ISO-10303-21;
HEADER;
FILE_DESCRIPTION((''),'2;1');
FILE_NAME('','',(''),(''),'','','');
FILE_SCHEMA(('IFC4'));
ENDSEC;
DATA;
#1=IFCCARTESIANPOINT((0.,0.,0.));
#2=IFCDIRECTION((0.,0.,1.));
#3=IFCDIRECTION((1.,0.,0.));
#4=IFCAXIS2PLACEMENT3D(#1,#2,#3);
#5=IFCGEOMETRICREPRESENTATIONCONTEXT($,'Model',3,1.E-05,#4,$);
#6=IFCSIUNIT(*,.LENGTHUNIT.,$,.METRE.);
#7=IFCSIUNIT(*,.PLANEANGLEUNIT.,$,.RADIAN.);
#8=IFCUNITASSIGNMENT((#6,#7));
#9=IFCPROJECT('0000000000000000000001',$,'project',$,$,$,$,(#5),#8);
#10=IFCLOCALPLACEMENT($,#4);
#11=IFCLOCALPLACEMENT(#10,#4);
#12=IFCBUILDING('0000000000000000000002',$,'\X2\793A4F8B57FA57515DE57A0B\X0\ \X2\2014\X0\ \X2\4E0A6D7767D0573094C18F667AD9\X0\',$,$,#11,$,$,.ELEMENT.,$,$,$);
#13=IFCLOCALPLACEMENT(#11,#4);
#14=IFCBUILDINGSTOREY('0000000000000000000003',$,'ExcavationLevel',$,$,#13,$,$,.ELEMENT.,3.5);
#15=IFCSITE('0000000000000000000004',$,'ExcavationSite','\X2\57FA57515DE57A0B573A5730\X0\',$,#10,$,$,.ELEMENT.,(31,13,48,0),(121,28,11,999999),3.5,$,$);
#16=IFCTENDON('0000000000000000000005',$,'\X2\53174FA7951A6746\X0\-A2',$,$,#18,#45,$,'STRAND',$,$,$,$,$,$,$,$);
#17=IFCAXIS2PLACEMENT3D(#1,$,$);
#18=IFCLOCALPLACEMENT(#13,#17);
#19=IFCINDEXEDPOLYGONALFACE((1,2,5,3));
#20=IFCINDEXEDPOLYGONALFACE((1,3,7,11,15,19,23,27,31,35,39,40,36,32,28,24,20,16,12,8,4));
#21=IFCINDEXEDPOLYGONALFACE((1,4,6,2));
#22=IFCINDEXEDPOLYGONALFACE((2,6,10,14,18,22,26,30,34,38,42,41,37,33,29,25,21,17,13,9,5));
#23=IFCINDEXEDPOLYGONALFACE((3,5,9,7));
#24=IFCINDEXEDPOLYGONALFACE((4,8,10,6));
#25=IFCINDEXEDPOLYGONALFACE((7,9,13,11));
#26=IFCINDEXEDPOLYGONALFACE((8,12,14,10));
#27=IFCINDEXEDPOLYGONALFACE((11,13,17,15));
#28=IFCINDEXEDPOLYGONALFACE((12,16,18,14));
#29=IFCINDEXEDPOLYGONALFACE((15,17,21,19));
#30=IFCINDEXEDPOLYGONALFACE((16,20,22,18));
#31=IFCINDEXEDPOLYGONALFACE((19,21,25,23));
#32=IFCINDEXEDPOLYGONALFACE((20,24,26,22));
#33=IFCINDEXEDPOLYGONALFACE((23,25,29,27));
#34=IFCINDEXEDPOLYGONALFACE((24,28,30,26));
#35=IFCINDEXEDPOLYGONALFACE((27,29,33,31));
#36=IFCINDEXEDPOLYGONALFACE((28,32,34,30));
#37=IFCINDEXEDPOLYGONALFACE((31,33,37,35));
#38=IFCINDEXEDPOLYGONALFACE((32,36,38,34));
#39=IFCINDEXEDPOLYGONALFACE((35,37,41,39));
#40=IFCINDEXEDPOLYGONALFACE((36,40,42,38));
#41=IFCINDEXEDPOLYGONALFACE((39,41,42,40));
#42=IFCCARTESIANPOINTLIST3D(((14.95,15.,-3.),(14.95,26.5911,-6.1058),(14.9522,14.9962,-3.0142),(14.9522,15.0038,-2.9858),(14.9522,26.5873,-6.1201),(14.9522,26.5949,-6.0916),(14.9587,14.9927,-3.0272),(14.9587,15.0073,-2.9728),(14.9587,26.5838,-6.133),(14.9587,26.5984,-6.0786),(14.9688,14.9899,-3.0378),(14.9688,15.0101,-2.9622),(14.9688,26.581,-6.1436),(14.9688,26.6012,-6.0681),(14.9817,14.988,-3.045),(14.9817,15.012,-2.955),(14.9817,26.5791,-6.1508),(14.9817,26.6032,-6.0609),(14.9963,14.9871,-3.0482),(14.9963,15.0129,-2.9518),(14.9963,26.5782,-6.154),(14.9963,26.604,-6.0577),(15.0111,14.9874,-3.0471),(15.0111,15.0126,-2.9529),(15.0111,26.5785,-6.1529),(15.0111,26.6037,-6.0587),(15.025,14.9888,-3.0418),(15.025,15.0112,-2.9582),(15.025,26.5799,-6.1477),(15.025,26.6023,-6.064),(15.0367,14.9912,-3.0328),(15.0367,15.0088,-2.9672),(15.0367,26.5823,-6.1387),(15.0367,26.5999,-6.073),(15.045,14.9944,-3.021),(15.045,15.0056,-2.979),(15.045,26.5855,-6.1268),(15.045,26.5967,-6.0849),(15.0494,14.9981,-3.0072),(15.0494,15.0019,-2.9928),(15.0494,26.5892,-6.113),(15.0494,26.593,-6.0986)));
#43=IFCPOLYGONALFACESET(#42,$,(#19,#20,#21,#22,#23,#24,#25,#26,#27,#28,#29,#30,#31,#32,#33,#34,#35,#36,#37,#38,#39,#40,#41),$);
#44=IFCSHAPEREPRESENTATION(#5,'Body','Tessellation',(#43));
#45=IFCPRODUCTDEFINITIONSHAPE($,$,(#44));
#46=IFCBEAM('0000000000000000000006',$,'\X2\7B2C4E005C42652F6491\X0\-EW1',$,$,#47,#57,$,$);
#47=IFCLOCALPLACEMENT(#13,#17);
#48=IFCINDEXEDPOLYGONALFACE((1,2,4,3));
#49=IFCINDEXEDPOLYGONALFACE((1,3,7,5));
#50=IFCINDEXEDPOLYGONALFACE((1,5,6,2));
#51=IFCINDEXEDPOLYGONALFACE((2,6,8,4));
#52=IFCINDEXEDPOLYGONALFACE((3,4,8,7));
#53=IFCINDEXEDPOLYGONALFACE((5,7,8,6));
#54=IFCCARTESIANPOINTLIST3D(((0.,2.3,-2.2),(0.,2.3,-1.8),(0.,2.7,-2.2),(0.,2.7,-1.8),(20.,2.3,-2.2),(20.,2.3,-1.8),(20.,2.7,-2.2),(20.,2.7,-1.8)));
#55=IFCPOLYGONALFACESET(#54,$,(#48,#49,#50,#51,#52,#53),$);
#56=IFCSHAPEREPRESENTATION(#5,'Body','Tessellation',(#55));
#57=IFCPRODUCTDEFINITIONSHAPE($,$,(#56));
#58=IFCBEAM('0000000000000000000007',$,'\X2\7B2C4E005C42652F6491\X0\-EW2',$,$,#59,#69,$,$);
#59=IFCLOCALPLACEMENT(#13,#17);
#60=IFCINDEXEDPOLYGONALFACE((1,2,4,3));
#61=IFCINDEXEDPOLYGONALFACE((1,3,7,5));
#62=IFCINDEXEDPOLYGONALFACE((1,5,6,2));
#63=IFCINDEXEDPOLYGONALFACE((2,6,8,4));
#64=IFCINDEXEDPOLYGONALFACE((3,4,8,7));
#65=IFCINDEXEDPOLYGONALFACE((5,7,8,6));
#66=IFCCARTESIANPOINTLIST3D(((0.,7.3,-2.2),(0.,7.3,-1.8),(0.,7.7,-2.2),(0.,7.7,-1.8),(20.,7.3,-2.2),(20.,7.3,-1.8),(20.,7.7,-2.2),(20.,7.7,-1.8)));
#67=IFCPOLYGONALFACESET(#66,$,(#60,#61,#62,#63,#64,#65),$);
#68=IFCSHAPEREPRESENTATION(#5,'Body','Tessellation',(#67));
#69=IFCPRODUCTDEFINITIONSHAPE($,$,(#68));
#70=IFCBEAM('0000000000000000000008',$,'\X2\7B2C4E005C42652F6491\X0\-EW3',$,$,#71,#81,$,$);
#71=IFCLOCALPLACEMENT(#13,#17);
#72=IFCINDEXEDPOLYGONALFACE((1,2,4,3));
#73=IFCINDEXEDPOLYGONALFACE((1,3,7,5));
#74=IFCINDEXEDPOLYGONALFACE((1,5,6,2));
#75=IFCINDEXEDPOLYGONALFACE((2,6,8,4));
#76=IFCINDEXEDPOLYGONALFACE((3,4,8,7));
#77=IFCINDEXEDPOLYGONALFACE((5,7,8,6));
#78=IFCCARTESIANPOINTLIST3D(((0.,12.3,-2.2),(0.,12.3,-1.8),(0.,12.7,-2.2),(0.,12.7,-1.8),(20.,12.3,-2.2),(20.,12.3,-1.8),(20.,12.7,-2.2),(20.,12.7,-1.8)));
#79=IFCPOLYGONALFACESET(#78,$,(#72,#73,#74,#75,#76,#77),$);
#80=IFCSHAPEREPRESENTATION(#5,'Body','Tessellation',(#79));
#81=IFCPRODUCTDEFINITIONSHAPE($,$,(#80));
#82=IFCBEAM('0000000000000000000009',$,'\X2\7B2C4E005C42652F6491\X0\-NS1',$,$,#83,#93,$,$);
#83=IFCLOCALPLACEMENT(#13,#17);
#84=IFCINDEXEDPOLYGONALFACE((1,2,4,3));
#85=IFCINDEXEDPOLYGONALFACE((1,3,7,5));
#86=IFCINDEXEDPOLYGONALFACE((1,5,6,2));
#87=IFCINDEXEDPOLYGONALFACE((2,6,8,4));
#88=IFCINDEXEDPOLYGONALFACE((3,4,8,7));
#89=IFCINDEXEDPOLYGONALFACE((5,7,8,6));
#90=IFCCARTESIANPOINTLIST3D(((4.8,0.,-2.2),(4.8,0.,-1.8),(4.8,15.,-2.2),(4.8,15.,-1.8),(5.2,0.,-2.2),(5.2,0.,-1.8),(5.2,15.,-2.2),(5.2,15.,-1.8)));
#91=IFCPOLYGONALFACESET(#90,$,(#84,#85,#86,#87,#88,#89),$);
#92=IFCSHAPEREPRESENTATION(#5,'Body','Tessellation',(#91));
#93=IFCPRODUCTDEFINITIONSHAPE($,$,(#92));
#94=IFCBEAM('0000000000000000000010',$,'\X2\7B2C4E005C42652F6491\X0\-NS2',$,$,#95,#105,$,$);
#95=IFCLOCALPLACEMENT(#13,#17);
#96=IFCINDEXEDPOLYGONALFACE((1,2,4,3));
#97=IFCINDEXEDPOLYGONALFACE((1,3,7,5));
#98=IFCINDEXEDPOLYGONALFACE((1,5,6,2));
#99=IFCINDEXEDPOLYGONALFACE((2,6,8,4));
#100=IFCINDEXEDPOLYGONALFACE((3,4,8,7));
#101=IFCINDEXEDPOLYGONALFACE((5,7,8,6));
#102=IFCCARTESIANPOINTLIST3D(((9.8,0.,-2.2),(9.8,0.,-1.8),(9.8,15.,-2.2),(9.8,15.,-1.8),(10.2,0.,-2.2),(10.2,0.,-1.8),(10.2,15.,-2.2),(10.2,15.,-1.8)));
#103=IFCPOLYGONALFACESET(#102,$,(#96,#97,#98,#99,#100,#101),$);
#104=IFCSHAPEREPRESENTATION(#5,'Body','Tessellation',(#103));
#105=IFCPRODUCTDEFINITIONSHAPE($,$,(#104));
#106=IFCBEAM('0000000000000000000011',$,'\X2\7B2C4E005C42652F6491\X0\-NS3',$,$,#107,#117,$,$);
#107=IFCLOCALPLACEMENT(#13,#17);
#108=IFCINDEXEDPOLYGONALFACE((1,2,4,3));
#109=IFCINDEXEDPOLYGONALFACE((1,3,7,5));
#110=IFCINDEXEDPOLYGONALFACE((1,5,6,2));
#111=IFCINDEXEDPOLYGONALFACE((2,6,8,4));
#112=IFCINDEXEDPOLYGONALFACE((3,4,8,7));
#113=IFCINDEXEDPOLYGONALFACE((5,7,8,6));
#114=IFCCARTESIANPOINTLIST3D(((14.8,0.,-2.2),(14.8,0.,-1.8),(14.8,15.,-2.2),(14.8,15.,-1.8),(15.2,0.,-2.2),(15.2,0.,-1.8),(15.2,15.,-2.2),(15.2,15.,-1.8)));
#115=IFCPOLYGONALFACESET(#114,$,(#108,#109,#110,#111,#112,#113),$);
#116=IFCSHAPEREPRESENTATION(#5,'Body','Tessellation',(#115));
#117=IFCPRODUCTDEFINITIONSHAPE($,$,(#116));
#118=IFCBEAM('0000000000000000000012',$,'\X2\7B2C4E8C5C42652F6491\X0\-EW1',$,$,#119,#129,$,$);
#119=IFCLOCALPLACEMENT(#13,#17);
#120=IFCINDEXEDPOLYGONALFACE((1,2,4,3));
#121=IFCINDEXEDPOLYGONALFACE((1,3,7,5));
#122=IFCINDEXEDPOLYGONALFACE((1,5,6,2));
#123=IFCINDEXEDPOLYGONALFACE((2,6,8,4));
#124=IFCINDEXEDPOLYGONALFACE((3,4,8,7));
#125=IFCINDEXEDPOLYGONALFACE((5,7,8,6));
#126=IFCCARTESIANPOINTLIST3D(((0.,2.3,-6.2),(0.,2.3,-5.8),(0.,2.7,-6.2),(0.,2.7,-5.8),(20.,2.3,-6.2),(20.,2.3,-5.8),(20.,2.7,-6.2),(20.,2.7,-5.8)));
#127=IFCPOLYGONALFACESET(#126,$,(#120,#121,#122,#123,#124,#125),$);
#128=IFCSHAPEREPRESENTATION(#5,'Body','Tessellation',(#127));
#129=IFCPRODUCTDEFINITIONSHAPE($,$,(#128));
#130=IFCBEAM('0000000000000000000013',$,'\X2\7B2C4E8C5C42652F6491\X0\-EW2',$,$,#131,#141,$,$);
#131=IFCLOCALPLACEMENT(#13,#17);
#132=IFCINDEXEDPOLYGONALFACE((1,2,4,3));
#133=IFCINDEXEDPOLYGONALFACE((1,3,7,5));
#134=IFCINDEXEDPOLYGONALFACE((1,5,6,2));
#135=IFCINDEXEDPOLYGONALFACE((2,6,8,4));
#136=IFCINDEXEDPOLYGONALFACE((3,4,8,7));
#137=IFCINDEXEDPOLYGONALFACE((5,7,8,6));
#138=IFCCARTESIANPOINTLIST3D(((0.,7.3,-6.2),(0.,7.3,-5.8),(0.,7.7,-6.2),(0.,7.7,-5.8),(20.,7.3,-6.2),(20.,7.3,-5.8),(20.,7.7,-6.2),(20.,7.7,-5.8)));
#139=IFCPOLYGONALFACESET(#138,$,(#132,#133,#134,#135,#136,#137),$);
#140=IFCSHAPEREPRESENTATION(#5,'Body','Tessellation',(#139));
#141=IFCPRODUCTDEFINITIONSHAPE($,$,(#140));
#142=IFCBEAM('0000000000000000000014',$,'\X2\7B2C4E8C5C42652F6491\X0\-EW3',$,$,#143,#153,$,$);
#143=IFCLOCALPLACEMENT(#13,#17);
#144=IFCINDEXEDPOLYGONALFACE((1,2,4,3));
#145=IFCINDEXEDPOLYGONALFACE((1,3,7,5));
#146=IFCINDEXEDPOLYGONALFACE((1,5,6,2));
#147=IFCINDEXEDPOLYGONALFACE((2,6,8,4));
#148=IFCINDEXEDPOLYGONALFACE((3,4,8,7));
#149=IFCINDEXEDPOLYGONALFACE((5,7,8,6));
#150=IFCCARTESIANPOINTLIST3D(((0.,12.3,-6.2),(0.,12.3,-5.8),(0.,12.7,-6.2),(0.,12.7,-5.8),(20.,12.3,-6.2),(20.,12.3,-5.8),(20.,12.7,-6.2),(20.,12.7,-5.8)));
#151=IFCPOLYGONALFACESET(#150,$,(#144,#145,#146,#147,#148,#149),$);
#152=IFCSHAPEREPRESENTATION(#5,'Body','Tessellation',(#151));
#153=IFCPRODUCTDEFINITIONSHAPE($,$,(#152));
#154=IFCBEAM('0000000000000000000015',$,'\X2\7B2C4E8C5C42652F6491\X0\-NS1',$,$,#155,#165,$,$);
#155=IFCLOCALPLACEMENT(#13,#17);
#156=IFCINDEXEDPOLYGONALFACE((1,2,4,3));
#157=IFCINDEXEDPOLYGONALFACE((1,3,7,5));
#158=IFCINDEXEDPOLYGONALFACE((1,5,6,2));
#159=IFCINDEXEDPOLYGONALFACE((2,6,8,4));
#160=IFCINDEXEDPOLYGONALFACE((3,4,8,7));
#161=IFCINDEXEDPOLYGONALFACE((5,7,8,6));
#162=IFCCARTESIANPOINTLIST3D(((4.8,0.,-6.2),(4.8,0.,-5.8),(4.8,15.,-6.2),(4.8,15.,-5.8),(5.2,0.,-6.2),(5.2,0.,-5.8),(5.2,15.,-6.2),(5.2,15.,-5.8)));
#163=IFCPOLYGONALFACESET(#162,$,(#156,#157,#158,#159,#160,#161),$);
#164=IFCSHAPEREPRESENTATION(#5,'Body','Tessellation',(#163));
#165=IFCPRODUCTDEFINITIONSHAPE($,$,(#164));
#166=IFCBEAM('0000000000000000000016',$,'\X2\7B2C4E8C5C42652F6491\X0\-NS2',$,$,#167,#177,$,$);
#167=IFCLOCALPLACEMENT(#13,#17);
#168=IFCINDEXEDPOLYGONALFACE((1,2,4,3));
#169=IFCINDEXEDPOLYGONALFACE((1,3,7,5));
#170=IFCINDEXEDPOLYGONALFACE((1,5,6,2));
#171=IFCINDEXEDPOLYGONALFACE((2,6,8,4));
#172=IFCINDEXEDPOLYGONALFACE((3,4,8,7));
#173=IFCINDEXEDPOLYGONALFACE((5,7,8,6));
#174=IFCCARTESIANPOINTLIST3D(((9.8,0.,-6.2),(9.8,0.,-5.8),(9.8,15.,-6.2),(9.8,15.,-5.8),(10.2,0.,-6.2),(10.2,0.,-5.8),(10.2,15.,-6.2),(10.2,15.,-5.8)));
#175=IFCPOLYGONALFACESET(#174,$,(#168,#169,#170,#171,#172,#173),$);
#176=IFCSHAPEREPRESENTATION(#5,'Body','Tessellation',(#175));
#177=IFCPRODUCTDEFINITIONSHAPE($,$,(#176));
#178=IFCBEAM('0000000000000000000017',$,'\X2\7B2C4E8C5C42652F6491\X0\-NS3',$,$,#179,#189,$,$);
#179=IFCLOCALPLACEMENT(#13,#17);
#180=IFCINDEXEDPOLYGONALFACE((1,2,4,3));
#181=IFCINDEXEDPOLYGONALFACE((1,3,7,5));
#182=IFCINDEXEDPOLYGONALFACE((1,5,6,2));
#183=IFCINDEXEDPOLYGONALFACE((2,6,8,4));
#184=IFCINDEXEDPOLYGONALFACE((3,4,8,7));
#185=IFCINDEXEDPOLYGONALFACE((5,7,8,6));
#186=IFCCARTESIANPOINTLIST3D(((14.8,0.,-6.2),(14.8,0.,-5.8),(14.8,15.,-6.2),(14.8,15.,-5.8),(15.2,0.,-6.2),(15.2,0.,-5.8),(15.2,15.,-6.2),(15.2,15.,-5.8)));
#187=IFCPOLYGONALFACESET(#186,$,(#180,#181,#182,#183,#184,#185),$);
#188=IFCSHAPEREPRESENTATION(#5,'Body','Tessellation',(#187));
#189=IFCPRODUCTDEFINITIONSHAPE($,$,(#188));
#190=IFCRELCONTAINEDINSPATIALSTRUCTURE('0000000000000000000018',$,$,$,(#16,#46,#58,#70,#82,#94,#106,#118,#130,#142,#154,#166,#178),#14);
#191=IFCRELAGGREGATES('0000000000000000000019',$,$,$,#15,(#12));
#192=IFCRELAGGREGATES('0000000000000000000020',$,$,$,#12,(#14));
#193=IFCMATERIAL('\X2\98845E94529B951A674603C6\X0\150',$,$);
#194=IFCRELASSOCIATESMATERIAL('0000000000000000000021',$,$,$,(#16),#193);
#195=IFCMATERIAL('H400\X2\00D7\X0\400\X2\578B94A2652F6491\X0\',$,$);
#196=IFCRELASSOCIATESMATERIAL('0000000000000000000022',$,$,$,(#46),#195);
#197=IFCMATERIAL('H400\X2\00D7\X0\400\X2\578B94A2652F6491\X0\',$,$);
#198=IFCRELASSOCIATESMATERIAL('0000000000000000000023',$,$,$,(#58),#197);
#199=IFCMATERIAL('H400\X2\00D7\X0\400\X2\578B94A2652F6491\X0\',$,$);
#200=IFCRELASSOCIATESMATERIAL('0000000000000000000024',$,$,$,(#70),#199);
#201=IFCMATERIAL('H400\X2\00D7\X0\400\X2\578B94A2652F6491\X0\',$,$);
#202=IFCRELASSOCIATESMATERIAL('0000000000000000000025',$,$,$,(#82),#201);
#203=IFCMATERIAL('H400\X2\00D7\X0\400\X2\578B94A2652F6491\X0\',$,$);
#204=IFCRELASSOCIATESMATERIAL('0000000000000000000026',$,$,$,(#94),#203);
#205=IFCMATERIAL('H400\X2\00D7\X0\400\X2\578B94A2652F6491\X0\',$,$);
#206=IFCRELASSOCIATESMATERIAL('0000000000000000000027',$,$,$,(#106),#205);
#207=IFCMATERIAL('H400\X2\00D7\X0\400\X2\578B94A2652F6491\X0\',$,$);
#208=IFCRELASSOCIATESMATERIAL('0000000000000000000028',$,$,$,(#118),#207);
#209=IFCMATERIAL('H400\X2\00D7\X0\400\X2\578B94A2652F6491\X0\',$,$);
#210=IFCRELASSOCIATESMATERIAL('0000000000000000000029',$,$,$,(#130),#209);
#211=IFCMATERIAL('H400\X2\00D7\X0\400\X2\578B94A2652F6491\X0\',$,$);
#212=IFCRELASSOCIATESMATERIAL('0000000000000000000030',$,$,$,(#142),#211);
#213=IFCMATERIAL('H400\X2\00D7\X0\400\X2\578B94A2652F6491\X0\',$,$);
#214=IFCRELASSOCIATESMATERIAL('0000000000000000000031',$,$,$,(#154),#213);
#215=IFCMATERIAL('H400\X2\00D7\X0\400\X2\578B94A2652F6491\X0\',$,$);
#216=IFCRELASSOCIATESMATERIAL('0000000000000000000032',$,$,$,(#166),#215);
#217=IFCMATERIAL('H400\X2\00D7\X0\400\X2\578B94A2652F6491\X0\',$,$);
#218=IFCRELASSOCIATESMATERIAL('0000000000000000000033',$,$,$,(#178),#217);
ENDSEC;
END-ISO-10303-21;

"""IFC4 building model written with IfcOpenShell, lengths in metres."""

from ifc_helpers import new_model, si_unit, frame, origin_with_axes, origin_2d, place, context, project, spatial, polyline, circle, outline, extrude, material, element, save


model = new_model("IFC4")

# Units and contexts
model_context = context("Model", 3, precision=1e-05, world=origin_with_axes())
ifc_project = project(units=[si_unit("LENGTHUNIT", "METRE"), si_unit("PLANEANGLEUNIT", "RADIAN")], contexts=[model_context])

# Site, building, storey
site_placement = place(None, origin_with_axes())
site = spatial("IfcSite", at=site_placement, Name="ExcavationSite", Description="基坑工程场地", CompositionType="ELEMENT", RefLatitude=(31, 13, 48, 0), RefLongitude=(121, 28, 11, 999999), RefElevation=3.5)
building_placement = place(site_placement, origin_with_axes())
building = spatial("IfcBuilding", under=site, at=building_placement, Name="示例基坑工程 — 上海某地铁车站", CompositionType="ELEMENT")
storey_placement = place(building_placement, origin_with_axes())
storey = spatial("IfcBuildingStorey", under=building, at=storey_placement, Name="ExcavationLevel", CompositionType="ELEMENT", Elevation=3.5)

# Tendon
ifc_material_1 = material(Name="预应力锚杆φ150")
tendon_1_placement = place(site_placement, origin_with_axes())
element("IfcTendon", 1, at=tendon_1_placement, inside=storey, material=ifc_material_1, Name="北侧锚杆-A2", SteelGrade="STRAND", context=model_context, shape_type="SweptSolid", body=[
    extrude(circle(Radius=0.05, at=origin_2d()), frame((15.0, 15.0, -3.0), z_axis=(0.0, 0.965926, -0.258819), x_axis=(-1.0, 0.0, 0.0)), (0.0, 0.0, 1.0), 12.0),
])

# Beams
ifc_material_2 = material(Name="H400×400型钢支撑")
beam_1_placement = place(site_placement, origin_with_axes())
element("IfcBeam", 2, at=beam_1_placement, inside=storey, material=ifc_material_2, Name="第一层支撑-EW1", context=model_context, shape_type="SweptSolid", body=[
    extrude(outline(polyline([(-0.2, -0.2), (0.2, -0.2), (0.2, 0.2), (-0.2, 0.2), (-0.2, -0.2)])), frame((0.0, 2.5, -2.0), z_axis=(1.0, 0.0, 0.0), x_axis=(0.0, 1.0, 0.0)), (0.0, 0.0, 1.0), 20.0),
])
ifc_material_3 = material(Name="H400×400型钢支撑")
beam_2_placement = place(site_placement, origin_with_axes())
element("IfcBeam", 3, at=beam_2_placement, inside=storey, material=ifc_material_3, Name="第一层支撑-EW2", context=model_context, shape_type="SweptSolid", body=[
    extrude(outline(polyline([(-0.2, -0.2), (0.2, -0.2), (0.2, 0.2), (-0.2, 0.2), (-0.2, -0.2)])), frame((0.0, 7.5, -2.0), z_axis=(1.0, 0.0, 0.0), x_axis=(0.0, 1.0, 0.0)), (0.0, 0.0, 1.0), 20.0),
])
ifc_material_4 = material(Name="H400×400型钢支撑")
beam_3_placement = place(site_placement, origin_with_axes())
element("IfcBeam", 4, at=beam_3_placement, inside=storey, material=ifc_material_4, Name="第一层支撑-EW3", context=model_context, shape_type="SweptSolid", body=[
    extrude(outline(polyline([(-0.2, -0.2), (0.2, -0.2), (0.2, 0.2), (-0.2, 0.2), (-0.2, -0.2)])), frame((0.0, 12.5, -2.0), z_axis=(1.0, 0.0, 0.0), x_axis=(0.0, 1.0, 0.0)), (0.0, 0.0, 1.0), 20.0),
])
ifc_material_5 = material(Name="H400×400型钢支撑")
beam_4_placement = place(site_placement, origin_with_axes())
element("IfcBeam", 5, at=beam_4_placement, inside=storey, material=ifc_material_5, Name="第一层支撑-NS1", context=model_context, shape_type="SweptSolid", body=[
    extrude(outline(polyline([(-0.2, -0.2), (0.2, -0.2), (0.2, 0.2), (-0.2, 0.2), (-0.2, -0.2)])), frame((5.0, 0.0, -2.0), z_axis=(0.0, 1.0, 0.0), x_axis=(-1.0, 0.0, 0.0)), (0.0, 0.0, 1.0), 15.0),
])
ifc_material_6 = material(Name="H400×400型钢支撑")
beam_5_placement = place(site_placement, origin_with_axes())
element("IfcBeam", 6, at=beam_5_placement, inside=storey, material=ifc_material_6, Name="第一层支撑-NS2", context=model_context, shape_type="SweptSolid", body=[
    extrude(outline(polyline([(-0.2, -0.2), (0.2, -0.2), (0.2, 0.2), (-0.2, 0.2), (-0.2, -0.2)])), frame((10.0, 0.0, -2.0), z_axis=(0.0, 1.0, 0.0), x_axis=(-1.0, 0.0, 0.0)), (0.0, 0.0, 1.0), 15.0),
])
ifc_material_7 = material(Name="H400×400型钢支撑")
beam_6_placement = place(site_placement, origin_with_axes())
element("IfcBeam", 7, at=beam_6_placement, inside=storey, material=ifc_material_7, Name="第一层支撑-NS3", context=model_context, shape_type="SweptSolid", body=[
    extrude(outline(polyline([(-0.2, -0.2), (0.2, -0.2), (0.2, 0.2), (-0.2, 0.2), (-0.2, -0.2)])), frame((15.0, 0.0, -2.0), z_axis=(0.0, 1.0, 0.0), x_axis=(-1.0, 0.0, 0.0)), (0.0, 0.0, 1.0), 15.0),
])
ifc_material_8 = material(Name="H400×400型钢支撑")
beam_7_placement = place(site_placement, origin_with_axes())
element("IfcBeam", 8, at=beam_7_placement, inside=storey, material=ifc_material_8, Name="第二层支撑-EW1", context=model_context, shape_type="SweptSolid", body=[
    extrude(outline(polyline([(-0.2, -0.2), (0.2, -0.2), (0.2, 0.2), (-0.2, 0.2), (-0.2, -0.2)])), frame((0.0, 2.5, -6.0), z_axis=(1.0, 0.0, 0.0), x_axis=(0.0, 1.0, 0.0)), (0.0, 0.0, 1.0), 20.0),
])
ifc_material_9 = material(Name="H400×400型钢支撑")
beam_8_placement = place(site_placement, origin_with_axes())
element("IfcBeam", 9, at=beam_8_placement, inside=storey, material=ifc_material_9, Name="第二层支撑-EW2", context=model_context, shape_type="SweptSolid", body=[
    extrude(outline(polyline([(-0.2, -0.2), (0.2, -0.2), (0.2, 0.2), (-0.2, 0.2), (-0.2, -0.2)])), frame((0.0, 7.5, -6.0), z_axis=(1.0, 0.0, 0.0), x_axis=(0.0, 1.0, 0.0)), (0.0, 0.0, 1.0), 20.0),
])
ifc_material_10 = material(Name="H400×400型钢支撑")
beam_9_placement = place(site_placement, origin_with_axes())
element("IfcBeam", 10, at=beam_9_placement, inside=storey, material=ifc_material_10, Name="第二层支撑-EW3", context=model_context, shape_type="SweptSolid", body=[
    extrude(outline(polyline([(-0.2, -0.2), (0.2, -0.2), (0.2, 0.2), (-0.2, 0.2), (-0.2, -0.2)])), frame((0.0, 12.5, -6.0), z_axis=(1.0, 0.0, 0.0), x_axis=(0.0, 1.0, 0.0)), (0.0, 0.0, 1.0), 20.0),
])
ifc_material_11 = material(Name="H400×400型钢支撑")
beam_10_placement = place(site_placement, origin_with_axes())
element("IfcBeam", 11, at=beam_10_placement, inside=storey, material=ifc_material_11, Name="第二层支撑-NS1", context=model_context, shape_type="SweptSolid", body=[
    extrude(outline(polyline([(-0.2, -0.2), (0.2, -0.2), (0.2, 0.2), (-0.2, 0.2), (-0.2, -0.2)])), frame((5.0, 0.0, -6.0), z_axis=(0.0, 1.0, 0.0), x_axis=(-1.0, 0.0, 0.0)), (0.0, 0.0, 1.0), 15.0),
])
ifc_material_12 = material(Name="H400×400型钢支撑")
beam_11_placement = place(site_placement, origin_with_axes())
element("IfcBeam", 12, at=beam_11_placement, inside=storey, material=ifc_material_12, Name="第二层支撑-NS2", context=model_context, shape_type="SweptSolid", body=[
    extrude(outline(polyline([(-0.2, -0.2), (0.2, -0.2), (0.2, 0.2), (-0.2, 0.2), (-0.2, -0.2)])), frame((10.0, 0.0, -6.0), z_axis=(0.0, 1.0, 0.0), x_axis=(-1.0, 0.0, 0.0)), (0.0, 0.0, 1.0), 15.0),
])
ifc_material_13 = material(Name="H400×400型钢支撑")
beam_12_placement = place(site_placement, origin_with_axes())
element("IfcBeam", 13, at=beam_12_placement, inside=storey, material=ifc_material_13, Name="第二层支撑-NS3", context=model_context, shape_type="SweptSolid", body=[
    extrude(outline(polyline([(-0.2, -0.2), (0.2, -0.2), (0.2, 0.2), (-0.2, 0.2), (-0.2, -0.2)])), frame((15.0, 0.0, -6.0), z_axis=(0.0, 1.0, 0.0), x_axis=(-1.0, 0.0, 0.0)), (0.0, 0.0, 1.0), 15.0),
])

save(model, "model.ifc")
